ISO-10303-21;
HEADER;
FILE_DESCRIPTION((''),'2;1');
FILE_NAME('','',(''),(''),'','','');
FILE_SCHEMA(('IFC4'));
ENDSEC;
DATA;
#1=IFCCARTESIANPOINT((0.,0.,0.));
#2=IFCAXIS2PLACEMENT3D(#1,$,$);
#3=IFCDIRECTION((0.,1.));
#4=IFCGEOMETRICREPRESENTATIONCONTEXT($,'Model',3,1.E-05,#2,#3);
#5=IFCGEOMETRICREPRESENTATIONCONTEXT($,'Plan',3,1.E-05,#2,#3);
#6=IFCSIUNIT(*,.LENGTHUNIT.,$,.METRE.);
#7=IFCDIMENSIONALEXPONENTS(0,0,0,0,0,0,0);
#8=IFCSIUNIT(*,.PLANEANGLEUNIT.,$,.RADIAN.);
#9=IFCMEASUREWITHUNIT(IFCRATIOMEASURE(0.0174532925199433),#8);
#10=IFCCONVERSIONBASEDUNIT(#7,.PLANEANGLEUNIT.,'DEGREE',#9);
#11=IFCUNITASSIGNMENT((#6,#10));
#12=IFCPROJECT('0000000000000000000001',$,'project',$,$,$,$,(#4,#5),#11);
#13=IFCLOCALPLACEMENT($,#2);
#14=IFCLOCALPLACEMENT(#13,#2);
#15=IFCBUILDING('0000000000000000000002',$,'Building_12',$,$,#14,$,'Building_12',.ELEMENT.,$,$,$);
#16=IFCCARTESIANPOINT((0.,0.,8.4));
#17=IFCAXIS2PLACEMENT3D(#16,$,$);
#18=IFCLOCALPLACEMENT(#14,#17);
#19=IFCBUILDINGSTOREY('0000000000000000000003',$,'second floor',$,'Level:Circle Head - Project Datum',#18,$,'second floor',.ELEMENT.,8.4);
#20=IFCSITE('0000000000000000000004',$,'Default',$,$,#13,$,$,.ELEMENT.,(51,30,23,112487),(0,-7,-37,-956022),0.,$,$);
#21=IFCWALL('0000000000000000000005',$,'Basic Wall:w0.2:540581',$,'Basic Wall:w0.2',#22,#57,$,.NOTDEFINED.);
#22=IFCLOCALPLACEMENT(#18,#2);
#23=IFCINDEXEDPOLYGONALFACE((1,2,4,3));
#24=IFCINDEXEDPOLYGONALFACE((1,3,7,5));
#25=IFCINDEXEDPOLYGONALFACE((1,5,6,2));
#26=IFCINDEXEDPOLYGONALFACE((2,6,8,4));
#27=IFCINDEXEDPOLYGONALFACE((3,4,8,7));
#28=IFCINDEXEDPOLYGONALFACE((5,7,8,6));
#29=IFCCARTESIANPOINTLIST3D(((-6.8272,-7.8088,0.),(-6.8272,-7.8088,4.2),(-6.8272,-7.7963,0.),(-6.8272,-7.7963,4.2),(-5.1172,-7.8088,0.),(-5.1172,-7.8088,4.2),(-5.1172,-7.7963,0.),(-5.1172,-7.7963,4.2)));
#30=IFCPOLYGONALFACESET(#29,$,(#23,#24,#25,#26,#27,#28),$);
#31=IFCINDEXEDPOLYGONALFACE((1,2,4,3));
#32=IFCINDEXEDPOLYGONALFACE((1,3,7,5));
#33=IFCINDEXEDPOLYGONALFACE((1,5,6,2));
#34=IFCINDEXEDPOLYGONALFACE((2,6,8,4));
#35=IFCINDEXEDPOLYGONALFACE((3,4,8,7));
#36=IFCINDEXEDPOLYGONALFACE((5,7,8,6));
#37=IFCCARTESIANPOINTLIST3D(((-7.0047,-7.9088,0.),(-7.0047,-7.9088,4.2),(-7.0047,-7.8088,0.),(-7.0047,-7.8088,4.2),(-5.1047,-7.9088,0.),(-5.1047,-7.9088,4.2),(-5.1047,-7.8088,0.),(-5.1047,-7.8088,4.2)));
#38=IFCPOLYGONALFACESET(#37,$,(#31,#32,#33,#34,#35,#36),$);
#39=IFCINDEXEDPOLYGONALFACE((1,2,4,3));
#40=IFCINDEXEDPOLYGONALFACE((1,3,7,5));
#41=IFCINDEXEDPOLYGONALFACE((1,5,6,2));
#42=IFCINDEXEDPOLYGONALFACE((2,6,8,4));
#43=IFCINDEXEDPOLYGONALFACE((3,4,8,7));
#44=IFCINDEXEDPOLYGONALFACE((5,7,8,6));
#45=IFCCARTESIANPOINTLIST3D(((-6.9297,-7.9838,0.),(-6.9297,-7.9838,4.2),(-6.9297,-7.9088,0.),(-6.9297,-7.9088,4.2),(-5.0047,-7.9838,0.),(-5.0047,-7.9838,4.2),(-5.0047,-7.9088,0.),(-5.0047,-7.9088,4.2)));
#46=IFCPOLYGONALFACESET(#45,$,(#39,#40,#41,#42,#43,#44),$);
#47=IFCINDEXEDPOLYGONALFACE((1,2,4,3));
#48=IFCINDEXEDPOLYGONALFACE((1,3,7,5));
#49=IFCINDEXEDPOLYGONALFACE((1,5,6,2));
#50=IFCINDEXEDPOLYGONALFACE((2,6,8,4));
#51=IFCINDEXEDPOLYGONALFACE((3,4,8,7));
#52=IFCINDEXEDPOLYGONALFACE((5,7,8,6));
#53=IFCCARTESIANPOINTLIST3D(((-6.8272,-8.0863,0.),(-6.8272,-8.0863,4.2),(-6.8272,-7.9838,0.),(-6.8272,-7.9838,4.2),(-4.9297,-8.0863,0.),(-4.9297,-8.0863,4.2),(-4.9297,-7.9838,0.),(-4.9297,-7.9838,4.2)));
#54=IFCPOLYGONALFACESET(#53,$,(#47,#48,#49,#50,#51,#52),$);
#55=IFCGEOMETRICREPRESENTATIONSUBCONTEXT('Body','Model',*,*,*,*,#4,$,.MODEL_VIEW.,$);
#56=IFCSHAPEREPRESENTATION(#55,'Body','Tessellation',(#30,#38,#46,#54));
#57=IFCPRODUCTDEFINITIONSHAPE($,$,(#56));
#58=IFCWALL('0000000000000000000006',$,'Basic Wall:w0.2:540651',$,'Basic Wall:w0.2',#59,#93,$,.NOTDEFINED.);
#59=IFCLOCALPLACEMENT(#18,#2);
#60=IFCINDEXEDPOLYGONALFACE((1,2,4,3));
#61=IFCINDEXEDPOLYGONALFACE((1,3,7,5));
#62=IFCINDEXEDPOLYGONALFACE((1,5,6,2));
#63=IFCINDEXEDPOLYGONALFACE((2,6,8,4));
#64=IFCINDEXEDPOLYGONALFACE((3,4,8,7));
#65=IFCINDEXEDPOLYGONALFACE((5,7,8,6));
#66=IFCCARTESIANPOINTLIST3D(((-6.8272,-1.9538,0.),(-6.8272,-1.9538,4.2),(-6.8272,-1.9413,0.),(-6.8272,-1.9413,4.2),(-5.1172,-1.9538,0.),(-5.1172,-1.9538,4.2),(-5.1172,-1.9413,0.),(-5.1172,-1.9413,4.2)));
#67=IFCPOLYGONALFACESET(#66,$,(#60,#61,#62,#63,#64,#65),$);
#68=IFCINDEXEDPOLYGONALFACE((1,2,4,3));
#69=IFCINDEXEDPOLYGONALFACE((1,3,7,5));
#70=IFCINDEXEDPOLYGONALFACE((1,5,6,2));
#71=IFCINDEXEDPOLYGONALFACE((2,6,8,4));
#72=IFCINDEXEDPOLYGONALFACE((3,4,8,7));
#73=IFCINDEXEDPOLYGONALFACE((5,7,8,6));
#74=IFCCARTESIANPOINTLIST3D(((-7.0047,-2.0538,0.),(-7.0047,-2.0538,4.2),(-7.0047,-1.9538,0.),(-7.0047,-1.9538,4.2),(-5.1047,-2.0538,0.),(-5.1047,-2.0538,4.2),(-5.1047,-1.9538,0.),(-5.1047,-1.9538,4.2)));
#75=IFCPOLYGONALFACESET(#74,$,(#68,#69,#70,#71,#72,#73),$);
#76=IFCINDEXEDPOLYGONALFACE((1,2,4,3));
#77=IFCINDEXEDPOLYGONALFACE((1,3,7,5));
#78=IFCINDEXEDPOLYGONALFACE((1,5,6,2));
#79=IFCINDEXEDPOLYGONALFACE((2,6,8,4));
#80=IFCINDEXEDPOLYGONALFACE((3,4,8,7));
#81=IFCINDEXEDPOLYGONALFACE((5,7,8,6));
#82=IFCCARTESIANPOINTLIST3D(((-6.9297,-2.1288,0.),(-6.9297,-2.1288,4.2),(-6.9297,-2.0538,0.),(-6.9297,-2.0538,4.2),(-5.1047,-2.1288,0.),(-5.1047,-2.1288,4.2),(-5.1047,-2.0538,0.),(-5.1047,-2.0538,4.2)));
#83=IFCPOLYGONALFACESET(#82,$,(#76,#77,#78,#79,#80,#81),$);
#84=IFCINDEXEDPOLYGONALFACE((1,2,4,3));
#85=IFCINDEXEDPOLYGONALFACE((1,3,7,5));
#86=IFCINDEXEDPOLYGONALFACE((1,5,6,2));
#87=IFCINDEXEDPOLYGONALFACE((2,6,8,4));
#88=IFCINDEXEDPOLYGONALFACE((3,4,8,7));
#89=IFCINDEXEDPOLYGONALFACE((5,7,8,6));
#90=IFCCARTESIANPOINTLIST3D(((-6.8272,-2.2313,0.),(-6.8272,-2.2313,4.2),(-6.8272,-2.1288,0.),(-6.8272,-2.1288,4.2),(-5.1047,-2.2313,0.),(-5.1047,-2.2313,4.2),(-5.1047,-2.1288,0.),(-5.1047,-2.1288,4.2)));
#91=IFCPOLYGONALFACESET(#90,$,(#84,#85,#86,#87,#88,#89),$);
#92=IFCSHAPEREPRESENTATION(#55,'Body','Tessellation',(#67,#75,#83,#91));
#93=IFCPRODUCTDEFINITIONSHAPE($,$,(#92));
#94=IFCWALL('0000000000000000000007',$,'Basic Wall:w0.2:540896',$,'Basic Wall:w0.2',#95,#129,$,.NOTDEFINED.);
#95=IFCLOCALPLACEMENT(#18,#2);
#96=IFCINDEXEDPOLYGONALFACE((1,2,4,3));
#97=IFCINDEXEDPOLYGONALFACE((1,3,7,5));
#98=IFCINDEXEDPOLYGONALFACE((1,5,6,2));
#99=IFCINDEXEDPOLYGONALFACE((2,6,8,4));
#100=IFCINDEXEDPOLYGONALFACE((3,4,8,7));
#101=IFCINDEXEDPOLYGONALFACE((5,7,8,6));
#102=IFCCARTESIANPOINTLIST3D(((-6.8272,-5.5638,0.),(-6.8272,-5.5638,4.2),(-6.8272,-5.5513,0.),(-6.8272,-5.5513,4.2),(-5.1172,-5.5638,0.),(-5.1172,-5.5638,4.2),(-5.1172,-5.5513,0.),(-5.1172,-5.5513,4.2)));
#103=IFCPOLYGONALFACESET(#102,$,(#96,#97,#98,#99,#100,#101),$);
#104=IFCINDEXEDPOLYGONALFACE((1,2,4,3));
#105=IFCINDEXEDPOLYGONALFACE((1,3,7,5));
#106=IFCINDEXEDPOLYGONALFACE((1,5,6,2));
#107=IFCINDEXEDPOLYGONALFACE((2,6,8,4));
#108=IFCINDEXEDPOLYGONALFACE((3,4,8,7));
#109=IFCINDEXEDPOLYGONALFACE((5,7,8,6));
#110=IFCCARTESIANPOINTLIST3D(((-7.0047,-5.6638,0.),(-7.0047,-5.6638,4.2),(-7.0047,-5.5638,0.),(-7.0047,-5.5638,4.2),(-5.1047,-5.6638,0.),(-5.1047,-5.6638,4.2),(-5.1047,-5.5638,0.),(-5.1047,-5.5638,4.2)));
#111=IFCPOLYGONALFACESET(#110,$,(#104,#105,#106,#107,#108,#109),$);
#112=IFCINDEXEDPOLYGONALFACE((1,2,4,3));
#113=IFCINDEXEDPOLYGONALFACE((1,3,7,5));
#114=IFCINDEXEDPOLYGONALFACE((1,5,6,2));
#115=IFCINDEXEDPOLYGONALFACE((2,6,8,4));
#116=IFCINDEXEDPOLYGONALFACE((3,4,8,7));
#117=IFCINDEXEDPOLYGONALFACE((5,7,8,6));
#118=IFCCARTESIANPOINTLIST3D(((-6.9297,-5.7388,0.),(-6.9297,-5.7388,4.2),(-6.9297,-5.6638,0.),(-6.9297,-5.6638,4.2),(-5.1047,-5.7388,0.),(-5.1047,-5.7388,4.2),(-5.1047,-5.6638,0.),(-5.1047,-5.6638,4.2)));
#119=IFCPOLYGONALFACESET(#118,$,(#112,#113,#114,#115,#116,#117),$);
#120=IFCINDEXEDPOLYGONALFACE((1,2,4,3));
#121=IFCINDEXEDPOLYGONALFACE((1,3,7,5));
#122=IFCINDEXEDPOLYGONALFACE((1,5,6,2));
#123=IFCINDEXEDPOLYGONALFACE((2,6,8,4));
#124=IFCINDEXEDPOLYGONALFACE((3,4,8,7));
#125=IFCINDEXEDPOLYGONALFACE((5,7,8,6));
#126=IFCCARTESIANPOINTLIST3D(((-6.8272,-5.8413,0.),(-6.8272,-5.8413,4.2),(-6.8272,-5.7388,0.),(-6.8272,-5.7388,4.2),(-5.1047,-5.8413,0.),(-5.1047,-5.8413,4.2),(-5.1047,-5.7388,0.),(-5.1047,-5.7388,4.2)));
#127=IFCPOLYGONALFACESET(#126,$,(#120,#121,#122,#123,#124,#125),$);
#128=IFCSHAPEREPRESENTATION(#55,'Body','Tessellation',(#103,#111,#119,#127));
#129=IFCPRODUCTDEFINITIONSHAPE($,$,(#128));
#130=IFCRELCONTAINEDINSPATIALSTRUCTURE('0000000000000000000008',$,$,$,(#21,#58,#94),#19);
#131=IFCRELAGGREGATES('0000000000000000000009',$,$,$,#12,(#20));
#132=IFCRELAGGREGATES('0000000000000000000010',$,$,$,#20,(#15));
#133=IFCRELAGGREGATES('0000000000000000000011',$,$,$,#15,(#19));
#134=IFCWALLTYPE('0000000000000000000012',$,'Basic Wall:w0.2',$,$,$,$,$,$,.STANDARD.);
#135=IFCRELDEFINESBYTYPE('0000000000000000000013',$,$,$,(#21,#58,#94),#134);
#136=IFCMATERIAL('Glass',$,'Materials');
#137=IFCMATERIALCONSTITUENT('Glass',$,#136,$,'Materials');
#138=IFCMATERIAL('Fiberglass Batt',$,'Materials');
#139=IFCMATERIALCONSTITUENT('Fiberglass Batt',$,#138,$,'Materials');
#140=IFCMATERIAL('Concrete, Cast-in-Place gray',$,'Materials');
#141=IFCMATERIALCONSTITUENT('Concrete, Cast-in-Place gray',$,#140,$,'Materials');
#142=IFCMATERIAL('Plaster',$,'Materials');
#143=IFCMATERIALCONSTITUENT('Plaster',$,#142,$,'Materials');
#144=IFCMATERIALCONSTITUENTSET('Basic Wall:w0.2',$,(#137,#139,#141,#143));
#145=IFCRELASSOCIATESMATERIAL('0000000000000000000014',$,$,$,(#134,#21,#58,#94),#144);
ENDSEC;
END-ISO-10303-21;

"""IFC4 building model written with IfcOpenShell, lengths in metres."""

from ifc_helpers import new_model, entity, si_unit, converted_unit, direction, frame, origin, place, context, subcontext, project, spatial, indexed_curve, outline, extrude, material, constituent, constituent_set, type_object, element, save


model = new_model("IFC4")

# Units and contexts
model_context = context("Model", 3, precision=1e-05, world=origin(), true_north=direction((0.0, 1.0)))
plan_context = context("Plan", 3, precision=1e-05, world=origin(), true_north=direction((0.0, 1.0)))
body_context = subcontext(model_context, "Body", "Model", "MODEL_VIEW")
ifc_project = project(units=[si_unit("LENGTHUNIT", "METRE"), converted_unit("PLANEANGLEUNIT", "DEGREE", entity("IfcRatioMeasure", 0.0174532925199433), si_unit("PLANEANGLEUNIT", "RADIAN"), dimensions=[0, 0, 0, 0, 0, 0, 0])], contexts=[model_context, plan_context])

# Site, building, storey
site_placement = place(None, origin())
site = spatial("IfcSite", under=ifc_project, at=site_placement, Name="Default", CompositionType="ELEMENT", RefLatitude=(51, 30, 23, 112487), RefLongitude=(0, -7, -37, -956022), RefElevation=0.0)
building_placement = place(site_placement, origin())
building = spatial("IfcBuilding", under=site, at=building_placement, Name="Building_12", LongName="Building_12", CompositionType="ELEMENT")
storey_placement = place(building_placement, frame((0.0, 0.0, 8.4)))
storey = spatial("IfcBuildingStorey", under=building, at=storey_placement, Name="second floor", ObjectType="Level:Circle Head - Project Datum", LongName="second floor", CompositionType="ELEMENT", Elevation=8.4)

# Shared definitions
ifc_material_1 = material(Name="Plaster", Category="Materials")
ifc_material_2 = material(Name="Glass", Category="Materials")

# Shared definitions
ifc_constituent_1 = constituent(ifc_material_2, Name="Glass", Category="Materials")
ifc_material_3 = material(Name="Fiberglass Batt", Category="Materials")
ifc_constituent_2 = constituent(ifc_material_3, Name="Fiberglass Batt", Category="Materials")
ifc_material_4 = material(Name="Concrete, Cast-in-Place gray", Category="Materials")
ifc_constituent_3 = constituent(ifc_material_4, Name="Concrete, Cast-in-Place gray", Category="Materials")
ifc_constituent_4 = constituent(ifc_material_1, Name="Plaster", Category="Materials")
ifc_constituent_set_1 = constituent_set(constituents=[ifc_constituent_1, ifc_constituent_2, ifc_constituent_3, ifc_constituent_4], Name="Basic Wall:w0.2")
wall_type = type_object("IfcWallType", Name="Basic Wall:w0.2", PredefinedType="STANDARD", material=ifc_constituent_set_1)

# Walls
wall_1_placement = place(storey_placement, frame((-5.1172, -7.9413, 0.0), z_axis=(0.0, 0.0, 1.0), x_axis=(-1.0, 0.0, 0.0)))
element("IfcWall", 1, at=wall_1_placement, inside=storey, type_object=wall_type, material=ifc_constituent_set_1, Name="Basic Wall:w0.2:540581", ObjectType="Basic Wall:w0.2", PredefinedType="NOTDEFINED", context=body_context, shape_type="SweptSolid", body=[
    extrude(outline(indexed_curve([(-0.0063, -0.855), (0.0062, -0.855), (0.0063, 0.855), (-0.0062, 0.855), (-0.0063, -0.855)], self_intersect=False)), frame((0.855, -0.1388, 0.0), z_axis=(0.0, 0.0, 1.0), x_axis=(0.0, 1.0, 0.0)), (0.0, 0.0, 1.0), 4.2),
    extrude(outline(indexed_curve([(-0.95, -0.05), (0.95, -0.05), (0.95, 0.05), (-0.95, 0.05), (-0.95, -0.05)], self_intersect=False)), frame((0.9375, -0.0825, 0.0)), (0.0, 0.0, 1.0), 4.2),
    extrude(outline(indexed_curve([(-0.9625, -0.0375), (0.9625, -0.0375), (0.9625, 0.0375), (-0.9625, 0.0375), (-0.9625, -0.0375)], self_intersect=False)), frame((0.85, 0.005, 0.0)), (0.0, 0.0, 1.0), 4.2),
    extrude(outline(indexed_curve([(-0.0513, -0.9488), (0.0512, -0.9488), (0.0513, 0.9487), (-0.0512, 0.9487), (-0.0513, -0.9488)], self_intersect=False)), frame((0.7613, 0.0938, 0.0), z_axis=(0.0, 0.0, 1.0), x_axis=(0.0, -1.0, 0.0)), (0.0, 0.0, 1.0), 4.2),
])
wall_2_placement = place(storey_placement, frame((-5.1172, -2.0863, 0.0), z_axis=(0.0, 0.0, 1.0), x_axis=(-1.0, 0.0, 0.0)))
element("IfcWall", 2, at=wall_2_placement, inside=storey, type_object=wall_type, material=ifc_constituent_set_1, Name="Basic Wall:w0.2:540651", ObjectType="Basic Wall:w0.2", PredefinedType="NOTDEFINED", context=body_context, shape_type="SweptSolid", body=[
    extrude(outline(indexed_curve([(-0.0063, -0.855), (0.0062, -0.855), (0.0063, 0.855), (-0.0062, 0.855), (-0.0063, -0.855)], self_intersect=False)), frame((0.855, -0.1388, 0.0), z_axis=(0.0, 0.0, 1.0), x_axis=(0.0, 1.0, 0.0)), (0.0, 0.0, 1.0), 4.2),
    extrude(outline(indexed_curve([(-0.95, -0.05), (0.95, -0.05), (0.95, 0.05), (-0.95, 0.05), (-0.95, -0.05)], self_intersect=False)), frame((0.9375, -0.0825, 0.0)), (0.0, 0.0, 1.0), 4.2),
    extrude(outline(indexed_curve([(-0.9125, -0.0375), (0.9125, -0.0375), (0.9125, 0.0375), (-0.9125, 0.0375), (-0.9125, -0.0375)], self_intersect=False)), frame((0.9, 0.005, 0.0)), (0.0, 0.0, 1.0), 4.2),
    extrude(outline(indexed_curve([(-0.0512, -0.8613), (0.0513, -0.8613), (0.0512, 0.8613), (-0.0513, 0.8612), (-0.0512, -0.8613)], self_intersect=False)), frame((0.8488, 0.0938, 0.0), z_axis=(0.0, 0.0, 1.0), x_axis=(0.0, -1.0, 0.0)), (0.0, 0.0, 1.0), 4.2),
])
wall_3_placement = place(storey_placement, frame((-5.1172, -5.6963, 0.0), z_axis=(0.0, 0.0, 1.0), x_axis=(-1.0, 0.0, 0.0)))
element("IfcWall", 3, at=wall_3_placement, inside=storey, type_object=wall_type, material=ifc_constituent_set_1, Name="Basic Wall:w0.2:540896", ObjectType="Basic Wall:w0.2", PredefinedType="NOTDEFINED", context=body_context, shape_type="SweptSolid", body=[
    extrude(outline(indexed_curve([(-0.0063, -0.855), (0.0062, -0.855), (0.0063, 0.855), (-0.0062, 0.855), (-0.0063, -0.855)], self_intersect=False)), frame((0.855, -0.1388, 0.0), z_axis=(0.0, 0.0, 1.0), x_axis=(0.0, 1.0, 0.0)), (0.0, 0.0, 1.0), 4.2),
    extrude(outline(indexed_curve([(-0.95, -0.05), (0.95, -0.05), (0.95, 0.05), (-0.95, 0.05), (-0.95, -0.05)], self_intersect=False)), frame((0.9375, -0.0825, 0.0)), (0.0, 0.0, 1.0), 4.2),
    extrude(outline(indexed_curve([(-0.9125, -0.0375), (0.9125, -0.0375), (0.9125, 0.0375), (-0.9125, 0.0375), (-0.9125, -0.0375)], self_intersect=False)), frame((0.9, 0.005, 0.0)), (0.0, 0.0, 1.0), 4.2),
    extrude(outline(indexed_curve([(-0.0513, -0.8612), (0.0512, -0.8612), (0.0513, 0.8613), (-0.0512, 0.8613), (-0.0513, -0.8612)], self_intersect=False)), frame((0.8487, 0.0938, 0.0), z_axis=(0.0, 0.0, 1.0), x_axis=(0.0, -1.0, 0.0)), (0.0, 0.0, 1.0), 4.2),
])

save(model, "model.ifc")
